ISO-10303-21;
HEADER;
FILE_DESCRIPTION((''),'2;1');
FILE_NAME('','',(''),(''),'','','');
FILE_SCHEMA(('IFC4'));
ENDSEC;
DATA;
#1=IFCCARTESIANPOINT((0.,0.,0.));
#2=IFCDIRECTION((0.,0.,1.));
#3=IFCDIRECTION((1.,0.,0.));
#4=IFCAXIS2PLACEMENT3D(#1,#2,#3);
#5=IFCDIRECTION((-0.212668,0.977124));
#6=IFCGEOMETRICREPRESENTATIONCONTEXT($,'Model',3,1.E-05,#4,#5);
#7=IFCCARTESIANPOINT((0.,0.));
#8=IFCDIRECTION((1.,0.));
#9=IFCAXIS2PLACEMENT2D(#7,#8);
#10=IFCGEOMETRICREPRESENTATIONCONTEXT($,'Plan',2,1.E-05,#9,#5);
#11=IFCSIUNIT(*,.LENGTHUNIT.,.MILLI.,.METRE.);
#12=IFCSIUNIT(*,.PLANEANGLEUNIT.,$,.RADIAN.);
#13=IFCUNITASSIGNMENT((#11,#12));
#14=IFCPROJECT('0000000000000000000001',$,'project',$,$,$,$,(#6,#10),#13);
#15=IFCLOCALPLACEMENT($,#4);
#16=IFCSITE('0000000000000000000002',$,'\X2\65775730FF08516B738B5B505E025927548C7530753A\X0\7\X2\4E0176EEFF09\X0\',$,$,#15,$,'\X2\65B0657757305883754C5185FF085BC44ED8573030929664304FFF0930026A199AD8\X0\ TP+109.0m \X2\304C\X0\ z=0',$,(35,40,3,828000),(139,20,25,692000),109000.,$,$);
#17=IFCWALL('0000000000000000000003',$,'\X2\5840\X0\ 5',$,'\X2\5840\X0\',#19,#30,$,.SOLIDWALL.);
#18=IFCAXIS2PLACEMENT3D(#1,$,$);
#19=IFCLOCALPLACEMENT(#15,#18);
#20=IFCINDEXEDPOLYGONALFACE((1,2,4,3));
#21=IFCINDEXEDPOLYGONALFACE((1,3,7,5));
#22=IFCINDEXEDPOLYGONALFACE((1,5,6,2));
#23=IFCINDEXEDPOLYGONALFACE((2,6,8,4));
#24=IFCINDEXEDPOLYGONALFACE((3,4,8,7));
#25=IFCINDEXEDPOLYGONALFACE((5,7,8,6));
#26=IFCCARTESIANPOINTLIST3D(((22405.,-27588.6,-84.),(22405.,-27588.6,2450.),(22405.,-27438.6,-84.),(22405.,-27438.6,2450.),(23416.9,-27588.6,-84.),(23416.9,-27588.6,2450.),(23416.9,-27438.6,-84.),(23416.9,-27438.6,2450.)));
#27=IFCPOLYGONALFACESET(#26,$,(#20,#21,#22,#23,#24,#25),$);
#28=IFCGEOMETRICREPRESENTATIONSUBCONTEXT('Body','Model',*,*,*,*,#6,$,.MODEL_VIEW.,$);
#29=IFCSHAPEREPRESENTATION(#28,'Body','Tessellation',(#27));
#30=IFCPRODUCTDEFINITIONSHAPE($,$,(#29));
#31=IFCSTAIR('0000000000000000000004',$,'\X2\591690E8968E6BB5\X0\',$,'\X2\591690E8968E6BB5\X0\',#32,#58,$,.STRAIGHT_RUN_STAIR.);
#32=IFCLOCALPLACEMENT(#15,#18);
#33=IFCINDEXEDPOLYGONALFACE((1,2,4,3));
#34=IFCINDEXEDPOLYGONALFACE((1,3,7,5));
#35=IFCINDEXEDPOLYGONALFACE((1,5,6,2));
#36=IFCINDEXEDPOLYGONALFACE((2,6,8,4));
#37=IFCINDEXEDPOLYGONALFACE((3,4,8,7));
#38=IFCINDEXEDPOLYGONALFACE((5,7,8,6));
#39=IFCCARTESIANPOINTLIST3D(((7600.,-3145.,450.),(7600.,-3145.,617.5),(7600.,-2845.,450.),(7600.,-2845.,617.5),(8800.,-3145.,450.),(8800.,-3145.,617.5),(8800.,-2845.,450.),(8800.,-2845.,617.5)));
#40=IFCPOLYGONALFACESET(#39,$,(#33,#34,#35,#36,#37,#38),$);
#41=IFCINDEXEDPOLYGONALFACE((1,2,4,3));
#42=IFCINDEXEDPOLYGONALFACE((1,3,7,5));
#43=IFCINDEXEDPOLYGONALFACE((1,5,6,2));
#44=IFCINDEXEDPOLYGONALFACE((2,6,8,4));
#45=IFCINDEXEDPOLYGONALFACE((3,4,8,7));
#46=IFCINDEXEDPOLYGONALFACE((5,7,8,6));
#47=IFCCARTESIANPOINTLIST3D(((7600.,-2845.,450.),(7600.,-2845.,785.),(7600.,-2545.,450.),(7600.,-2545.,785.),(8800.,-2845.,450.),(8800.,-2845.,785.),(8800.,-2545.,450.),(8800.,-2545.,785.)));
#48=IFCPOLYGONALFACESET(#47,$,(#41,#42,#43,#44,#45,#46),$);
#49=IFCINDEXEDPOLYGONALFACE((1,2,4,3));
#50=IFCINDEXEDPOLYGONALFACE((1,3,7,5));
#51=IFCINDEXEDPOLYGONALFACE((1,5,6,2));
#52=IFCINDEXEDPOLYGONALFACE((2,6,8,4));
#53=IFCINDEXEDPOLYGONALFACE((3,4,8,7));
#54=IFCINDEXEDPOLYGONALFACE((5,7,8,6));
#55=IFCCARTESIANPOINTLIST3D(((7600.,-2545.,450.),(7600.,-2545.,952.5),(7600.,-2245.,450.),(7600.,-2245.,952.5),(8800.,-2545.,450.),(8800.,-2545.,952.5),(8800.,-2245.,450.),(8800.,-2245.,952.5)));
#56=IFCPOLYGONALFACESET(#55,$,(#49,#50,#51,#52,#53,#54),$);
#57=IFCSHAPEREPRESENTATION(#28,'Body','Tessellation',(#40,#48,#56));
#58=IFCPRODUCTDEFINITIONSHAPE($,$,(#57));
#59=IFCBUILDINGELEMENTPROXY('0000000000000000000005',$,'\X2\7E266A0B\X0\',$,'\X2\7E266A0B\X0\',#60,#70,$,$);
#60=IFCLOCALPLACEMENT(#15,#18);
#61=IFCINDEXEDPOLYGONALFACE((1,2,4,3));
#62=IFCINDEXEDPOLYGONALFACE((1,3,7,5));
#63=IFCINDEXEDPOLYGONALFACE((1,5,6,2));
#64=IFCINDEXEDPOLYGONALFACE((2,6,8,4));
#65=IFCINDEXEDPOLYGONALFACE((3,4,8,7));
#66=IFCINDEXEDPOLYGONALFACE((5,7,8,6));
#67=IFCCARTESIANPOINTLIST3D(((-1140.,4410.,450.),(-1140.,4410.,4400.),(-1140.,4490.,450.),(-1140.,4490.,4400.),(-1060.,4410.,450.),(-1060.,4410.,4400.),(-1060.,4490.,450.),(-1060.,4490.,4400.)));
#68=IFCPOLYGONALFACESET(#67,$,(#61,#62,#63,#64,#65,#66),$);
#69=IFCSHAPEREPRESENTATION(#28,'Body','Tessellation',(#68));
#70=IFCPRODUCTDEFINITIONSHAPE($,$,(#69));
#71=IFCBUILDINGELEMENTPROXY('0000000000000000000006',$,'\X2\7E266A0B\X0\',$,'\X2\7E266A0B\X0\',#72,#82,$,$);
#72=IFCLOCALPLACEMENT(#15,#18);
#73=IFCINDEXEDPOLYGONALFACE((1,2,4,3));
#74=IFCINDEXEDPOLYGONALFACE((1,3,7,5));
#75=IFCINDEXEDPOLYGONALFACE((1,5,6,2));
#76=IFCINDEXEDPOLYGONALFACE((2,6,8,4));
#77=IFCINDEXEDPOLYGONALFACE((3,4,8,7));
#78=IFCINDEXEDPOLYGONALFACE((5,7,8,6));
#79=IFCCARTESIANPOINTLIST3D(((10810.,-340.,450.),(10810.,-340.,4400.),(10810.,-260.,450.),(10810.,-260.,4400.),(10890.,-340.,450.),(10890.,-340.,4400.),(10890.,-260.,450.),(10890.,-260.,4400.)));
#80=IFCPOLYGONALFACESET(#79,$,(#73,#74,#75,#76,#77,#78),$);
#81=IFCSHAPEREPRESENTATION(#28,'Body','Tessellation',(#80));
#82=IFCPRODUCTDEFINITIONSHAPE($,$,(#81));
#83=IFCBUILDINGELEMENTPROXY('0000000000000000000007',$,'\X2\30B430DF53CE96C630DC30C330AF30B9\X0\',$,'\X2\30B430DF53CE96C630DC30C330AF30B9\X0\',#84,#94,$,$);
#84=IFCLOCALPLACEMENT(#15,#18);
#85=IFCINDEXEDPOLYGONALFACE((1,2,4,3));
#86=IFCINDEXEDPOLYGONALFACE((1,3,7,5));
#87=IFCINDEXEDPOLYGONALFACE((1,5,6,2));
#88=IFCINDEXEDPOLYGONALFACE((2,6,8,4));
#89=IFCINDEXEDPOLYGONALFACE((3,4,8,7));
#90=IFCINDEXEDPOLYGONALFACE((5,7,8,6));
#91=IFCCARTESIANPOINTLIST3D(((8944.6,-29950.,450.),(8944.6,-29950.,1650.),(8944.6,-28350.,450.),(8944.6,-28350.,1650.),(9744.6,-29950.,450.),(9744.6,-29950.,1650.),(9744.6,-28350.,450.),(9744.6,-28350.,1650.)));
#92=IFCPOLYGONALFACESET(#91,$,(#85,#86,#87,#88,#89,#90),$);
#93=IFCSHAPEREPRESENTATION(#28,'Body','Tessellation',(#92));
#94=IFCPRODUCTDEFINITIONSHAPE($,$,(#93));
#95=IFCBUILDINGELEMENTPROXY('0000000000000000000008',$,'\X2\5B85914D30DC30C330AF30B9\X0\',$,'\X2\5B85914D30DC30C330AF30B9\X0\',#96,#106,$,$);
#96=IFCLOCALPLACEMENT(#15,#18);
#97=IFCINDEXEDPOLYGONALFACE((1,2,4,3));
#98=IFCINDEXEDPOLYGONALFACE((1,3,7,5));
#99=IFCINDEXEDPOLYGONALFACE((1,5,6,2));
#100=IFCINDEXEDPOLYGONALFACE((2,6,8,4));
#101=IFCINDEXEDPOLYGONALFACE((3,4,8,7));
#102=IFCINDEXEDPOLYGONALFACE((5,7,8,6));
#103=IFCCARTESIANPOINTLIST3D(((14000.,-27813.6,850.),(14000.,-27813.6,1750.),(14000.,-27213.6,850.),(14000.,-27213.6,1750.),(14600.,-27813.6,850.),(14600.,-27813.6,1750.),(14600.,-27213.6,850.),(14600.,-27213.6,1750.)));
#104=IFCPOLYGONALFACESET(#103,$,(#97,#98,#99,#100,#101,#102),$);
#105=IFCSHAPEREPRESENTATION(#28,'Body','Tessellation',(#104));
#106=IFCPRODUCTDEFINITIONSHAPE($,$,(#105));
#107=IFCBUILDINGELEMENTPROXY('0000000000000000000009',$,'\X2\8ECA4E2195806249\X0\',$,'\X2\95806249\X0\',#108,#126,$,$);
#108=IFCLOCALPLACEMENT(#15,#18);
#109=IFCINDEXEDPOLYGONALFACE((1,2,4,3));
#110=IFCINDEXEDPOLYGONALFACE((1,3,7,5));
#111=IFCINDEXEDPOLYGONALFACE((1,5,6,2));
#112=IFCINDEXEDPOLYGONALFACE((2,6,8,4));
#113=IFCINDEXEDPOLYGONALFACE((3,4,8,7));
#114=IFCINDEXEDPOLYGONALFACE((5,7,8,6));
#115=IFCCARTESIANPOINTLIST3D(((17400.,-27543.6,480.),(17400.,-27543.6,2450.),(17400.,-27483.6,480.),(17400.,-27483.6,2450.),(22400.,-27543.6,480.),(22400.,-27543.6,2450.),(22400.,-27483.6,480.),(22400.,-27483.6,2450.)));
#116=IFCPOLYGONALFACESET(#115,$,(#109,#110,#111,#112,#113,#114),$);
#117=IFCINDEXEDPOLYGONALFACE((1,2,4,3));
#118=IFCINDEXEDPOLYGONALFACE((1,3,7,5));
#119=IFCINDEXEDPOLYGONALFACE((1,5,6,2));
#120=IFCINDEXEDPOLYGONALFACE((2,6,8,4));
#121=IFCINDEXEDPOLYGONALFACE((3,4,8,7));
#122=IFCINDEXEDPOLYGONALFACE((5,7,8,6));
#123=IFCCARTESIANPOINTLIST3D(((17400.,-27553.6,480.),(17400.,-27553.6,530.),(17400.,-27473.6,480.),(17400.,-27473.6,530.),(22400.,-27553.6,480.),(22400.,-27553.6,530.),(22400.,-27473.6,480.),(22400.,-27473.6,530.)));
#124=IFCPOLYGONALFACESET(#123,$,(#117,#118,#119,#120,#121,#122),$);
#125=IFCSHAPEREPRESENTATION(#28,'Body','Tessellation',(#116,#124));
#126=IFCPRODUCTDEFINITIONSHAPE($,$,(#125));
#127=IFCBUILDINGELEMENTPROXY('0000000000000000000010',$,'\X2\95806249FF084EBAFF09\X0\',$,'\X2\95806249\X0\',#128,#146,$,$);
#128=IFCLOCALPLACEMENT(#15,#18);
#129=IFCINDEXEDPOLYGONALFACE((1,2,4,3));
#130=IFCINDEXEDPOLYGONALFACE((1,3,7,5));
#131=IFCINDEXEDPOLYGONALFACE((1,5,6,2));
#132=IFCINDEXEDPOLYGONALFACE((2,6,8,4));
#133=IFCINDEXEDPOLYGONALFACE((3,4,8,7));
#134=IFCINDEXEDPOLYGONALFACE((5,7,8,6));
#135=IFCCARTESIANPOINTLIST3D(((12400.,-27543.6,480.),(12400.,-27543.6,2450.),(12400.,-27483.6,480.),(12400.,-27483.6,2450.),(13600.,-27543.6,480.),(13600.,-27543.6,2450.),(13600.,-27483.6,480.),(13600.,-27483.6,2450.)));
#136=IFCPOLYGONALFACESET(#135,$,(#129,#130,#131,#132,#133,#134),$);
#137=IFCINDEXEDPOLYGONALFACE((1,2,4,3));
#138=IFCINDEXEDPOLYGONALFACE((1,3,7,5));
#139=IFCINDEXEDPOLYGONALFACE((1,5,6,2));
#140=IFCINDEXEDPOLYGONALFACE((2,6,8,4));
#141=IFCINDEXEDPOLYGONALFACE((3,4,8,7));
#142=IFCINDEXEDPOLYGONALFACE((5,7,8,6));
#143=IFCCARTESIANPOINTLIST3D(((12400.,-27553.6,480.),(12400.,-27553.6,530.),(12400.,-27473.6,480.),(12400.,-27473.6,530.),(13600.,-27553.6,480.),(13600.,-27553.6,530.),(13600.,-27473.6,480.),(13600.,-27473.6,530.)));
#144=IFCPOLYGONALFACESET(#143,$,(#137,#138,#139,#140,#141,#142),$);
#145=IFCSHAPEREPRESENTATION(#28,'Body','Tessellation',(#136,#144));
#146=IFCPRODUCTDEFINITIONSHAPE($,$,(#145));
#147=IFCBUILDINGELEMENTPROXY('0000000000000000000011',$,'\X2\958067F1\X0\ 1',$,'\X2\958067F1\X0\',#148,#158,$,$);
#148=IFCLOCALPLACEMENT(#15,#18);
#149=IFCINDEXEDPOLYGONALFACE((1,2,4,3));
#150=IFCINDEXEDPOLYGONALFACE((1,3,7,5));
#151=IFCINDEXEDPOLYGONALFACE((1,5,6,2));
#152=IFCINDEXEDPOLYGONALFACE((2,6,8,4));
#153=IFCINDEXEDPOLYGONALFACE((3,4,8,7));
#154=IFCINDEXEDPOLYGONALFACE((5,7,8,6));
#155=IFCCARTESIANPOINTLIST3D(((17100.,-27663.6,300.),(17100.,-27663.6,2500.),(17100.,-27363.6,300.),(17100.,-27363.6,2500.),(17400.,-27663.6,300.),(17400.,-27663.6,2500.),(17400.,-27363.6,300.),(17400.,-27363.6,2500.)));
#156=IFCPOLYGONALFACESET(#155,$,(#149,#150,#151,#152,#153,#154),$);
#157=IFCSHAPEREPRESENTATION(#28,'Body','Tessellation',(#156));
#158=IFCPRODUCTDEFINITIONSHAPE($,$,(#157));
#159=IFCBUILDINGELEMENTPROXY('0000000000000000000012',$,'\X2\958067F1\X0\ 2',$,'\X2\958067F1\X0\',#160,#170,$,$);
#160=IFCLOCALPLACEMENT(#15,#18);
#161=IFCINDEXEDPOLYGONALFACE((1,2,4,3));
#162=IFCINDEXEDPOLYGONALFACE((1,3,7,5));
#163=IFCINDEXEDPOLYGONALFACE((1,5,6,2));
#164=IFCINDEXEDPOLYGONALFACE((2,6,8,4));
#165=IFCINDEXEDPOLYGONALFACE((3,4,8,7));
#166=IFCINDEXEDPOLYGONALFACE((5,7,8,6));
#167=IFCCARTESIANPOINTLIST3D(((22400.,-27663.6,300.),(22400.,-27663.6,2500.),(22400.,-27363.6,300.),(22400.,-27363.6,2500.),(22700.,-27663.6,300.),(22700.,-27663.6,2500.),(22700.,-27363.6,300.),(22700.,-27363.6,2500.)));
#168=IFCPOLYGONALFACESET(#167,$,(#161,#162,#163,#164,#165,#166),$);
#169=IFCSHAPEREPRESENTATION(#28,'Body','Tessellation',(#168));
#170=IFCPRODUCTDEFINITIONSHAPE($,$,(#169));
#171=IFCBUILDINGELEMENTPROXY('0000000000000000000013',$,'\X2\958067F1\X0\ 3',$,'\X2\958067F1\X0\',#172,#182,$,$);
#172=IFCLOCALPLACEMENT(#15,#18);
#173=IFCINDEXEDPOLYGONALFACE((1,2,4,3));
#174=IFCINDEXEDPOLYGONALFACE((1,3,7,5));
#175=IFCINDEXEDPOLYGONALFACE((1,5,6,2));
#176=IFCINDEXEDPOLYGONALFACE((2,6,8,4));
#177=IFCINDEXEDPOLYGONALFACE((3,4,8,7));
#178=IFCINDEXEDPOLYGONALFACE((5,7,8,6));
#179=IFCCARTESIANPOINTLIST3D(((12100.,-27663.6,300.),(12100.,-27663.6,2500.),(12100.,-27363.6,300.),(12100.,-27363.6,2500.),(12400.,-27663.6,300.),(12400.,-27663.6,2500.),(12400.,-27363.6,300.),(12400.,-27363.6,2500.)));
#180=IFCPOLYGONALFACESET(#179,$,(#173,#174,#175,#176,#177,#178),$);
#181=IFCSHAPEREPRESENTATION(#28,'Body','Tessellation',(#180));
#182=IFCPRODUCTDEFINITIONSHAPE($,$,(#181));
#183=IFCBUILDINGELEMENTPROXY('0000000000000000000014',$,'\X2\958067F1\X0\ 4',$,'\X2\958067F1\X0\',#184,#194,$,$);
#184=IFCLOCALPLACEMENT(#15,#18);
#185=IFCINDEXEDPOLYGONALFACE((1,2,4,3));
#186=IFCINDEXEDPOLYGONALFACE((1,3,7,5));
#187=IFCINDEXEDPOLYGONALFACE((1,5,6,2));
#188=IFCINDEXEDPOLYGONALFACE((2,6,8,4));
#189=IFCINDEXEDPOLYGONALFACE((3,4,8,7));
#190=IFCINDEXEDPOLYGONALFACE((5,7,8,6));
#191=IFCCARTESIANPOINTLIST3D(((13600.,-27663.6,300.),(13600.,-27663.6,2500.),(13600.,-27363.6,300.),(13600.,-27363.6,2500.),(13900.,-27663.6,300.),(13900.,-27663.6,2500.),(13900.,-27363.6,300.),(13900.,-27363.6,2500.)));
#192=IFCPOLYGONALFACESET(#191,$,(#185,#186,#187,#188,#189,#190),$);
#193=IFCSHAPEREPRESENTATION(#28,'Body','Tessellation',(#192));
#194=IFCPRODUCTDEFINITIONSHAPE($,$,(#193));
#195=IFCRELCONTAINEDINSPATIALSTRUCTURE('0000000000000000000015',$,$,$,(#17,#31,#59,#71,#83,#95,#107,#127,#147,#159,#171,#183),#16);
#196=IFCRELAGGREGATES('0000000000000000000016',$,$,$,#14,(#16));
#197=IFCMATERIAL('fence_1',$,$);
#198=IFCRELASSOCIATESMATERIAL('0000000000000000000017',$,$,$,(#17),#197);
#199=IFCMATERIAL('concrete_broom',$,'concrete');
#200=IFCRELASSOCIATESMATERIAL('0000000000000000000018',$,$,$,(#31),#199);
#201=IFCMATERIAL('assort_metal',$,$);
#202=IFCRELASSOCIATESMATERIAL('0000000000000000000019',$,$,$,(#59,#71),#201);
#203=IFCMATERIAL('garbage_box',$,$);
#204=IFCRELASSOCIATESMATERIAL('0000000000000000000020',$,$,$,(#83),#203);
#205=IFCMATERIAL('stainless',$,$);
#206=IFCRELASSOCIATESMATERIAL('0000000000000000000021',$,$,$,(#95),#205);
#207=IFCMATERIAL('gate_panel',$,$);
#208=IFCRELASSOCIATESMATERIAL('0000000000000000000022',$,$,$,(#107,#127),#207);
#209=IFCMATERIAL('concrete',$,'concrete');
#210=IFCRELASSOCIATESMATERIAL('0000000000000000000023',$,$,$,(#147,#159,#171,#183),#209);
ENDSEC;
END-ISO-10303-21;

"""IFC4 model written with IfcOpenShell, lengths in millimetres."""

from ifc_helpers import new_model, si_unit, direction, frame, frame_2d, origin_with_axes, origin_2d_with_axis, place, context, subcontext, project, spatial, polyline, rectangle, outline, extrude, material, element, save


model = new_model("IFC4")

# Units and contexts
model_context = context("Model", 3, precision=1e-05, world=origin_with_axes(), true_north=direction((-0.212668, 0.977124)))
plan_context = context("Plan", 2, precision=1e-05, world=origin_2d_with_axis(), true_north=direction((-0.212668, 0.977124)))
body_context = subcontext(model_context, "Body", "Model", "MODEL_VIEW")
ifc_project = project(units=[si_unit("LENGTHUNIT", "METRE", prefix="MILLI"), si_unit("PLANEANGLEUNIT", "RADIAN")], contexts=[model_context, plan_context])

# Site
site_placement = place(None, origin_with_axes())
site = spatial("IfcSite", under=ifc_project, at=site_placement, Name="敷地（八王子市大和田町7丁目）", LongName="新敷地境界内（寄付地を除く）。標高 TP+109.0m が z=0", RefLatitude=(35, 40, 3, 828000), RefLongitude=(139, 20, 25, 692000), RefElevation=109000.0)

# Shared definitions
ifc_material_1 = material(Name="concrete_broom", Category="concrete")

# Wall
ifc_material_2 = material(Name="concrete", Category="concrete")
ifc_material_3 = material(Name="fence_1")
wall_1_placement = place(site_placement, origin_with_axes())
element("IfcWall", 1, at=wall_1_placement, inside=site, material=ifc_material_3, Name="塀 5", ObjectType="塀", PredefinedType="SOLIDWALL", context=body_context, shape_type="SweptSolid", body=[
    extrude(outline(polyline([(23416.9, -27438.6), (23416.9, -27588.6), (22405.0, -27588.6), (22405.0, -27438.6), (23416.9, -27438.6)])), frame((0.0, 0.0, -84.0)), (0.0, 0.0, 1.0), 2534.0),
])

# Stair
stair_placement = place(site_placement, origin_with_axes())
element("IfcStair", 2, at=stair_placement, inside=site, material=ifc_material_1, Name="外部階段", ObjectType="外部階段", PredefinedType="STRAIGHT_RUN_STAIR", context=body_context, shape_type="SweptSolid", body=[
    extrude(rectangle(XDim=1200.0, YDim=300.0, at=frame_2d((8200.0, -2995.0))), frame((0.0, 0.0, 450.0)), (0.0, 0.0, 1.0), 167.5),
    extrude(rectangle(XDim=1200.0, YDim=300.0, at=frame_2d((8200.0, -2695.0))), frame((0.0, 0.0, 450.0)), (0.0, 0.0, 1.0), 335.0),
    extrude(rectangle(XDim=1200.0, YDim=300.0, at=frame_2d((8200.0, -2395.0))), frame((0.0, 0.0, 450.0)), (0.0, 0.0, 1.0), 502.5),
])

# Building element proxies
ifc_material_4 = material(Name="assort_metal")
proxy_1_placement = place(site_placement, origin_with_axes())
element("IfcBuildingElementProxy", 3, at=proxy_1_placement, inside=site, material=ifc_material_4, Name="縦樋", ObjectType="縦樋", context=body_context, shape_type="SweptSolid", body=[
    extrude(rectangle(XDim=80.0, YDim=80.0, at=frame_2d((-1100.0, 4450.0))), frame((0.0, 0.0, 450.0)), (0.0, 0.0, 1.0), 3950.0),
])
proxy_2_placement = place(site_placement, origin_with_axes())
element("IfcBuildingElementProxy", 4, at=proxy_2_placement, inside=site, material=ifc_material_4, Name="縦樋", ObjectType="縦樋", context=body_context, shape_type="SweptSolid", body=[
    extrude(rectangle(XDim=80.0, YDim=80.0, at=frame_2d((10850.0, -300.0))), frame((0.0, 0.0, 450.0)), (0.0, 0.0, 1.0), 3950.0),
])
ifc_material_5 = material(Name="garbage_box")
proxy_3_placement = place(site_placement, origin_with_axes())
element("IfcBuildingElementProxy", 5, at=proxy_3_placement, inside=site, material=ifc_material_5, Name="ゴミ収集ボックス", ObjectType="ゴミ収集ボックス", context=body_context, shape_type="SweptSolid", body=[
    extrude(rectangle(XDim=800.0, YDim=1600.0, at=frame_2d((9344.6, -29150.0))), frame((0.0, 0.0, 450.0)), (0.0, 0.0, 1.0), 1200.0),
])
ifc_material_6 = material(Name="stainless")
proxy_4_placement = place(site_placement, origin_with_axes())
element("IfcBuildingElementProxy", 6, at=proxy_4_placement, inside=site, material=ifc_material_6, Name="宅配ボックス", ObjectType="宅配ボックス", context=body_context, shape_type="SweptSolid", body=[
    extrude(rectangle(XDim=600.0, YDim=600.0, at=frame_2d((14300.0, -27513.6))), frame((0.0, 0.0, 850.0)), (0.0, 0.0, 1.0), 900.0),
])
ifc_material_7 = material(Name="gate_panel")
proxy_5_placement = place(site_placement, origin_with_axes())
element("IfcBuildingElementProxy", 7, at=proxy_5_placement, inside=site, material=ifc_material_7, Name="車両門扉", ObjectType="門扉", context=body_context, shape_type="SweptSolid", body=[
    extrude(rectangle(XDim=5000.0, YDim=60.0, at=frame_2d((19900.0, -27513.6))), frame((0.0, 0.0, 480.0)), (0.0, 0.0, 1.0), 1970.0),
    extrude(rectangle(XDim=5000.0, YDim=80.0, at=frame_2d((19900.0, -27513.6))), frame((0.0, 0.0, 480.0)), (0.0, 0.0, 1.0), 50.0),
])
proxy_6_placement = place(site_placement, origin_with_axes())
element("IfcBuildingElementProxy", 8, at=proxy_6_placement, inside=site, material=ifc_material_7, Name="門扉（人）", ObjectType="門扉", context=body_context, shape_type="SweptSolid", body=[
    extrude(rectangle(XDim=1200.0, YDim=60.0, at=frame_2d((13000.0, -27513.6))), frame((0.0, 0.0, 480.0)), (0.0, 0.0, 1.0), 1970.0),
    extrude(rectangle(XDim=1200.0, YDim=80.0, at=frame_2d((13000.0, -27513.6))), frame((0.0, 0.0, 480.0)), (0.0, 0.0, 1.0), 50.0),
])
proxy_7_placement = place(site_placement, origin_with_axes())
element("IfcBuildingElementProxy", 9, at=proxy_7_placement, inside=site, material=ifc_material_2, Name="門柱 1", ObjectType="門柱", context=body_context, shape_type="SweptSolid", body=[
    extrude(rectangle(XDim=300.0, YDim=300.0, at=frame_2d((17250.0, -27513.6))), frame((0.0, 0.0, 300.0)), (0.0, 0.0, 1.0), 2200.0),
])
proxy_8_placement = place(site_placement, origin_with_axes())
element("IfcBuildingElementProxy", 10, at=proxy_8_placement, inside=site, material=ifc_material_2, Name="門柱 2", ObjectType="門柱", context=body_context, shape_type="SweptSolid", body=[
    extrude(rectangle(XDim=300.0, YDim=300.0, at=frame_2d((22550.0, -27513.6))), frame((0.0, 0.0, 300.0)), (0.0, 0.0, 1.0), 2200.0),
])
proxy_9_placement = place(site_placement, origin_with_axes())
element("IfcBuildingElementProxy", 11, at=proxy_9_placement, inside=site, material=ifc_material_2, Name="門柱 3", ObjectType="門柱", context=body_context, shape_type="SweptSolid", body=[
    extrude(rectangle(XDim=300.0, YDim=300.0, at=frame_2d((12250.0, -27513.6))), frame((0.0, 0.0, 300.0)), (0.0, 0.0, 1.0), 2200.0),
])
proxy_10_placement = place(site_placement, origin_with_axes())
element("IfcBuildingElementProxy", 12, at=proxy_10_placement, inside=site, material=ifc_material_2, Name="門柱 4", ObjectType="門柱", context=body_context, shape_type="SweptSolid", body=[
    extrude(rectangle(XDim=300.0, YDim=300.0, at=frame_2d((13750.0, -27513.6))), frame((0.0, 0.0, 300.0)), (0.0, 0.0, 1.0), 2200.0),
])

save(model, "model.ifc")
